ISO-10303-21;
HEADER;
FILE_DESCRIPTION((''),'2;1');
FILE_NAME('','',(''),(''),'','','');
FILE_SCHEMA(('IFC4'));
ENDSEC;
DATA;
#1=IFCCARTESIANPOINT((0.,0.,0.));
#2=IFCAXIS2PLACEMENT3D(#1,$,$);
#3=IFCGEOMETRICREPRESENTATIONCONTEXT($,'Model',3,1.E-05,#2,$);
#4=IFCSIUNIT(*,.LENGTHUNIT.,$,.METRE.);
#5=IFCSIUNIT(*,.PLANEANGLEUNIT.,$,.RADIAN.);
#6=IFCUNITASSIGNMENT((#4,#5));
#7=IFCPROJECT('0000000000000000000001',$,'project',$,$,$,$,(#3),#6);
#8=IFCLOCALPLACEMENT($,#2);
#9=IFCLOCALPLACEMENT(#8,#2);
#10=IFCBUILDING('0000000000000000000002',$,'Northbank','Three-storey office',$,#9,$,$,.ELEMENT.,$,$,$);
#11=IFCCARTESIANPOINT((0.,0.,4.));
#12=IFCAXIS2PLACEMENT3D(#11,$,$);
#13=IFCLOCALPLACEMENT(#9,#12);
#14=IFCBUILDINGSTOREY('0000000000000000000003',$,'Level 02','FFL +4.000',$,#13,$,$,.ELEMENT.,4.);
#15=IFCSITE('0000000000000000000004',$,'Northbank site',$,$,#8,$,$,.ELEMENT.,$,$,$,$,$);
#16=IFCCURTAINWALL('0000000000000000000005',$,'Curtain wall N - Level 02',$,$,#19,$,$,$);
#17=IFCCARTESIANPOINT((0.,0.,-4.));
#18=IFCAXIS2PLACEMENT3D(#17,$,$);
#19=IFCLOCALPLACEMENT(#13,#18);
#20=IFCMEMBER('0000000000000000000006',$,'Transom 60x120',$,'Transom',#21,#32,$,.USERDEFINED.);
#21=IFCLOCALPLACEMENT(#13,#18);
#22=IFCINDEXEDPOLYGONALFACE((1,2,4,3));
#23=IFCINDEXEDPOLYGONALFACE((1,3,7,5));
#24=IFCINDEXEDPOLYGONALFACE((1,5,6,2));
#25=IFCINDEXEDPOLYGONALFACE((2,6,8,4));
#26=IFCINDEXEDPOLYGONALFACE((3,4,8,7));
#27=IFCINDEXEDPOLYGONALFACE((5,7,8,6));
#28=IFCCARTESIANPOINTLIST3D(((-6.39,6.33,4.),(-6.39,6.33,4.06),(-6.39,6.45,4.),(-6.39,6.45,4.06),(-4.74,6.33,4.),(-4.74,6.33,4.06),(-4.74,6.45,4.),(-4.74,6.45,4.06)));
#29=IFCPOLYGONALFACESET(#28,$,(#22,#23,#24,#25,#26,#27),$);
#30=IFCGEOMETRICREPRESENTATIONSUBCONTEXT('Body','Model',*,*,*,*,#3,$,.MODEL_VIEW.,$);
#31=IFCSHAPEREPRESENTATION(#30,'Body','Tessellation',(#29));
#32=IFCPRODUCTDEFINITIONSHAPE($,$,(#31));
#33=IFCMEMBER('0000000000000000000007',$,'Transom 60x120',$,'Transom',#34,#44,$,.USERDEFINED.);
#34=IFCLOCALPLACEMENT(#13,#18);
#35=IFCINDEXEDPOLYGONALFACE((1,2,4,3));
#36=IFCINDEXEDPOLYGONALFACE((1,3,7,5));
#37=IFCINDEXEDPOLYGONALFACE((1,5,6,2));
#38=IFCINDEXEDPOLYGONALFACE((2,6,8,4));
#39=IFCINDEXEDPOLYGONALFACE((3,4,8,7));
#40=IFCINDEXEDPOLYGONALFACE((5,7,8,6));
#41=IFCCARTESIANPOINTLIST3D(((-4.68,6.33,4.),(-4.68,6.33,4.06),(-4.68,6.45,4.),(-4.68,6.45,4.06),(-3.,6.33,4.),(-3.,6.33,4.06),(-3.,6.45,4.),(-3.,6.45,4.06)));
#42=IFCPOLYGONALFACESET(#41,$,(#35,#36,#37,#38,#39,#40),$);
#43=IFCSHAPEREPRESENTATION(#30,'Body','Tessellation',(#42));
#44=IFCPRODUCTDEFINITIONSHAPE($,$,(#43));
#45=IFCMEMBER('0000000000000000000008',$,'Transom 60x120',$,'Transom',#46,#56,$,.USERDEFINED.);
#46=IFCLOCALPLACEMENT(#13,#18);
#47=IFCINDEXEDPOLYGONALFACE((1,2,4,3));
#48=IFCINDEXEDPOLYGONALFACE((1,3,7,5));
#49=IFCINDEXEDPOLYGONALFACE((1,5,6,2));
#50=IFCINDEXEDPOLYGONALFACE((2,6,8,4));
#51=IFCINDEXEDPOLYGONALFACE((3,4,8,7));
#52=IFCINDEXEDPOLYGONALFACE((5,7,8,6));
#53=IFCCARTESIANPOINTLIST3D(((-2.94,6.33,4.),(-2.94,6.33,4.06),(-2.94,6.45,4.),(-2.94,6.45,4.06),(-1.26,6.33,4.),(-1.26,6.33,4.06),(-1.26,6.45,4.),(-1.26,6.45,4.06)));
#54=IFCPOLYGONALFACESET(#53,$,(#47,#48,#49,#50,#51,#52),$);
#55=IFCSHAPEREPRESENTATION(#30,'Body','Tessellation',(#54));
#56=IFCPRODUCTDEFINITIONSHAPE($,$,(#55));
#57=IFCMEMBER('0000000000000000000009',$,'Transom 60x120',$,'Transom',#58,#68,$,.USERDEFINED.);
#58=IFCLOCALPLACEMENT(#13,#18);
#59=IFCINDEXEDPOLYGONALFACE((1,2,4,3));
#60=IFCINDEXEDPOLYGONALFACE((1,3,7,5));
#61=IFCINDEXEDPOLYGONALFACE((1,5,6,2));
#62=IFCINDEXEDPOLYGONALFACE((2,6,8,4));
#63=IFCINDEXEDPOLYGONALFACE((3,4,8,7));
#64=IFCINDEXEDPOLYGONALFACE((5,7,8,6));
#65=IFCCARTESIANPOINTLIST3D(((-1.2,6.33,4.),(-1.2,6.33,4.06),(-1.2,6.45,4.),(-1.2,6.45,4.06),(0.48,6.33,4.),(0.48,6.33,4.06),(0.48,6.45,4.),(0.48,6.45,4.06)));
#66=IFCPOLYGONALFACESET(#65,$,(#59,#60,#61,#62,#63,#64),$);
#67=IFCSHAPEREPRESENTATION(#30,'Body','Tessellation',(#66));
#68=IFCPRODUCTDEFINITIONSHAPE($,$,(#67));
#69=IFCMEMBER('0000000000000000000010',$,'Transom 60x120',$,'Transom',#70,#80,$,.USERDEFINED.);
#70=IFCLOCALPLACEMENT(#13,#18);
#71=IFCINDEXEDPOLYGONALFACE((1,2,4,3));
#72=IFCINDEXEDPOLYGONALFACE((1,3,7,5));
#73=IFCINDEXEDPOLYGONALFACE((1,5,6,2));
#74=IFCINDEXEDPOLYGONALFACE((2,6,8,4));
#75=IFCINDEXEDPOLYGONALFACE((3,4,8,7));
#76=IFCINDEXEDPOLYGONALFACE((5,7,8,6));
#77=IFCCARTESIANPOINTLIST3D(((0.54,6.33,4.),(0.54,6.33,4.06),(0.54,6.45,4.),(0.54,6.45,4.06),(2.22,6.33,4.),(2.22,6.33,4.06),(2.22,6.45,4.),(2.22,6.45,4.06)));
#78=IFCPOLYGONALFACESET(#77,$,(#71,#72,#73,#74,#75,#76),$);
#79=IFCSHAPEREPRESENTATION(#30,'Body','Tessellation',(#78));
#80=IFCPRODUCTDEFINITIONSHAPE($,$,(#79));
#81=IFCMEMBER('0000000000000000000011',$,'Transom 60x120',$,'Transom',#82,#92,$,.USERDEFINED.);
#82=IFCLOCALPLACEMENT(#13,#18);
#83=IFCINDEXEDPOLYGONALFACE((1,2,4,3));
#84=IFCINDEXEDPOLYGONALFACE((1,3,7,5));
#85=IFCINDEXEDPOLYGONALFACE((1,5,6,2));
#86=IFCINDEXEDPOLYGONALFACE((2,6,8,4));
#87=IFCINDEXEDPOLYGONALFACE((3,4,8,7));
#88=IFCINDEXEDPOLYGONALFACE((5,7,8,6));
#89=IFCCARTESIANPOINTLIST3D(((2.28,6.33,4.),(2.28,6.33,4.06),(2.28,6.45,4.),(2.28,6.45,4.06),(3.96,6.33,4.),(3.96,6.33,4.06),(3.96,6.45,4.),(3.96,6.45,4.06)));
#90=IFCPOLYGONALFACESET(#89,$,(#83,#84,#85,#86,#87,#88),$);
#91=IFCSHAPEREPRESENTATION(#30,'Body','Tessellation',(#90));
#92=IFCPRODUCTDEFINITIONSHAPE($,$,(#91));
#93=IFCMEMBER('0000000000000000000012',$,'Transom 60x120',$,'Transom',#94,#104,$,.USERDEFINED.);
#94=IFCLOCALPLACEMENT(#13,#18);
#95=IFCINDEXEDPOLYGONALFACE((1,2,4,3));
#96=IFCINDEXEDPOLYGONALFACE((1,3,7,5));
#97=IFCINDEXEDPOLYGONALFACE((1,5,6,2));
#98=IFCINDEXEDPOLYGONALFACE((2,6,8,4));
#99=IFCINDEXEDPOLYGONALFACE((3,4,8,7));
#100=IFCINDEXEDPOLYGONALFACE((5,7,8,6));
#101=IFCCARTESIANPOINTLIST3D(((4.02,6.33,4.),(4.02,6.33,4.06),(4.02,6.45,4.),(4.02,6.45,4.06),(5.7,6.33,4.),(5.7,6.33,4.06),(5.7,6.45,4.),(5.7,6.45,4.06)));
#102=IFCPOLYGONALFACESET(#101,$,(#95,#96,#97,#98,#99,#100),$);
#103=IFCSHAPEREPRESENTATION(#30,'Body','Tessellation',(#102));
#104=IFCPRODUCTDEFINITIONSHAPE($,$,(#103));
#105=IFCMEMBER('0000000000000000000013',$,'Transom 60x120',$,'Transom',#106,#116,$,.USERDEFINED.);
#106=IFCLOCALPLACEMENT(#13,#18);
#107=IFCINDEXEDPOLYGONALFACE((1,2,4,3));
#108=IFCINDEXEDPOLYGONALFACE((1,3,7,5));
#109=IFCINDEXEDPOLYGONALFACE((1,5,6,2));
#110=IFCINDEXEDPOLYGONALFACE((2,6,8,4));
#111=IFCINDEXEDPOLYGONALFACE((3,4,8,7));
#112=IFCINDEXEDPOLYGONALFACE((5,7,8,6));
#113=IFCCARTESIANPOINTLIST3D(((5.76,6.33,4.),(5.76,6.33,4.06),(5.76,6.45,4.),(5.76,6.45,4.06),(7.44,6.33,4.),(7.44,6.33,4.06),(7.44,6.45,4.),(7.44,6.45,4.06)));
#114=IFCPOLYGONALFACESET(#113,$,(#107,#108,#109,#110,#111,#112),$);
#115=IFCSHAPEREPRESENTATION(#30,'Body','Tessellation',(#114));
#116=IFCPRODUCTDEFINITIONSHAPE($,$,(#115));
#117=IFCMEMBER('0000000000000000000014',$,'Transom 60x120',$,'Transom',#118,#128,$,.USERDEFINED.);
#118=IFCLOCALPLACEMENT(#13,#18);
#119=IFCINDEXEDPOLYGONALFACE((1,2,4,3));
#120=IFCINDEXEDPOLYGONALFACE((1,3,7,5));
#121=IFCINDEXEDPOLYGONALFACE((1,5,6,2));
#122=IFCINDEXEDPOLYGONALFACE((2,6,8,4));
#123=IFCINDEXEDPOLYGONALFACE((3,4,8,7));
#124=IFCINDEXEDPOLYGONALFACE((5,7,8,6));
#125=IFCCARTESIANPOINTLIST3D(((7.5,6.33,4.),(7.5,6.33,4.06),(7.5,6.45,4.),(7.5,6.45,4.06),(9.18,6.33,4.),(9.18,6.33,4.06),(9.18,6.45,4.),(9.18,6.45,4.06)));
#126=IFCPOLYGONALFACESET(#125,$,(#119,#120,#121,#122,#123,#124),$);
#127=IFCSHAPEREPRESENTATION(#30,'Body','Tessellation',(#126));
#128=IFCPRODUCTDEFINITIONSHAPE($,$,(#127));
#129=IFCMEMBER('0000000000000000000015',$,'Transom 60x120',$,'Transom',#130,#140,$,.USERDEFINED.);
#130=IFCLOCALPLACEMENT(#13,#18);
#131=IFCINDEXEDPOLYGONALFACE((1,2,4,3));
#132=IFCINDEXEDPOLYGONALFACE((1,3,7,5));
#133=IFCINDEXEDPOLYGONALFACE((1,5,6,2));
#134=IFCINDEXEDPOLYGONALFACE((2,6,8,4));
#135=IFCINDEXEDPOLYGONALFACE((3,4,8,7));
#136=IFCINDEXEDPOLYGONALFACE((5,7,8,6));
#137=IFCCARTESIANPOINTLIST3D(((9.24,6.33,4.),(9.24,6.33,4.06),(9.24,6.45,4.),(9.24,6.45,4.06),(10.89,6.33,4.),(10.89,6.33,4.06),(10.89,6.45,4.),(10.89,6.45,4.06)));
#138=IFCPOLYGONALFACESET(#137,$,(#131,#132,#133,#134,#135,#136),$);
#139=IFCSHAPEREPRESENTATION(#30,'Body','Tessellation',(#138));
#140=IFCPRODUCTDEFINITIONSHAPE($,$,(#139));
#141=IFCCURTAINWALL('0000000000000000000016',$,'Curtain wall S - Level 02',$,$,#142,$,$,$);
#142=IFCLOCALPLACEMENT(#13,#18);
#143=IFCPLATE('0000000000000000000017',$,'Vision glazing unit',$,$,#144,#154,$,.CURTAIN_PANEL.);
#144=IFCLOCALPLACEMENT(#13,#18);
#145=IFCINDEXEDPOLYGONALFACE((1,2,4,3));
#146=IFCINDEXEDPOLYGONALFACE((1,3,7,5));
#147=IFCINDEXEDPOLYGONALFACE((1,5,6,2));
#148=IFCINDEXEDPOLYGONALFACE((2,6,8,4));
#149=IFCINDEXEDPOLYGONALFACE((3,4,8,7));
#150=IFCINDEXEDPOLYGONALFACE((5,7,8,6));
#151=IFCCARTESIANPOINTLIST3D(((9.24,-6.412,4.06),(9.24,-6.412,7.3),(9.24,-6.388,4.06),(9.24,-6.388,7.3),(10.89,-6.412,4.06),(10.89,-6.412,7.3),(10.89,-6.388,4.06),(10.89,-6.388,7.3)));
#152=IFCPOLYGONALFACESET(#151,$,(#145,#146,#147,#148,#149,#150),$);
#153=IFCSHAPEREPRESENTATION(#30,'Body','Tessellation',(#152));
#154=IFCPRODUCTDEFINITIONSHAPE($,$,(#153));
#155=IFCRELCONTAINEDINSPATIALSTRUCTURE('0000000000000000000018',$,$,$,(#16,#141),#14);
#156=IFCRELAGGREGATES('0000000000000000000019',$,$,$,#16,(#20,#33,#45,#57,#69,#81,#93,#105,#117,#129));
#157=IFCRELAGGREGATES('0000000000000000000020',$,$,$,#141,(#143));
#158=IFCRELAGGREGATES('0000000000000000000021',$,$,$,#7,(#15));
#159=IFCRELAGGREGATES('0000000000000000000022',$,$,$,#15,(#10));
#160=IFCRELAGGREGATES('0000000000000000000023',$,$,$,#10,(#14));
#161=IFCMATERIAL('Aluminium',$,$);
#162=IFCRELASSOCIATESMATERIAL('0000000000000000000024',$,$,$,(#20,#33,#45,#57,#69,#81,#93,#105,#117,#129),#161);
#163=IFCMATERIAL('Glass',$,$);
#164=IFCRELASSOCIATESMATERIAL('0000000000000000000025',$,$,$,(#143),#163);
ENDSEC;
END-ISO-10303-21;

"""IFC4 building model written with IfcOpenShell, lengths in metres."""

from ifc_helpers import new_model, si_unit, frame, origin, place, context, subcontext, project, spatial, rectangle, extrude, material, element, aggregate, save


model = new_model("IFC4")

# Units and contexts
model_context = context("Model", 3, precision=1e-05, world=origin())
body_context = subcontext(model_context, "Body", "Model", "MODEL_VIEW")
ifc_project = project(units=[si_unit("LENGTHUNIT", "METRE"), si_unit("PLANEANGLEUNIT", "RADIAN")], contexts=[model_context])

# Site, building, storey
site_placement = place(None, origin())
site = spatial("IfcSite", under=ifc_project, at=site_placement, Name="Northbank site", CompositionType="ELEMENT")
building_placement = place(site_placement, origin())
building = spatial("IfcBuilding", under=site, at=building_placement, Name="Northbank", Description="Three-storey office", CompositionType="ELEMENT")
storey_placement = place(building_placement, frame((0.0, 0.0, 4.0)))
storey = spatial("IfcBuildingStorey", under=building, at=storey_placement, Name="Level 02", Description="FFL +4.000", CompositionType="ELEMENT", Elevation=4.0)

# Curtain wall, members
curtain_wall_1_placement = place(storey_placement, frame((0.0, 0.0, -4.0)))
curtain_wall_1 = element("IfcCurtainWall", 1, at=curtain_wall_1_placement, inside=storey, Name="Curtain wall N - Level 02")
ifc_material_1 = material(Name="Aluminium")
member_1_placement = place(storey_placement, frame((0.0, 0.0, -4.0)))
member_1 = element("IfcMember", 2, at=member_1_placement, material=ifc_material_1, Name="Transom 60x120", ObjectType="Transom", PredefinedType="USERDEFINED", context=body_context, shape_type="SweptSolid", body=[
    extrude(rectangle(XDim=1.65, YDim=0.12), frame((-5.565, 6.39, 4.0)), (0.0, 0.0, 1.0), 0.06),
])
member_2_placement = place(storey_placement, frame((0.0, 0.0, -4.0)))
member_2 = element("IfcMember", 3, at=member_2_placement, material=ifc_material_1, Name="Transom 60x120", ObjectType="Transom", PredefinedType="USERDEFINED", context=body_context, shape_type="SweptSolid", body=[
    extrude(rectangle(XDim=1.68, YDim=0.12), frame((-3.84, 6.39, 4.0)), (0.0, 0.0, 1.0), 0.06),
])
member_3_placement = place(storey_placement, frame((0.0, 0.0, -4.0)))
member_3 = element("IfcMember", 4, at=member_3_placement, material=ifc_material_1, Name="Transom 60x120", ObjectType="Transom", PredefinedType="USERDEFINED", context=body_context, shape_type="SweptSolid", body=[
    extrude(rectangle(XDim=1.68, YDim=0.12), frame((-2.1, 6.39, 4.0)), (0.0, 0.0, 1.0), 0.06),
])
member_4_placement = place(storey_placement, frame((0.0, 0.0, -4.0)))
member_4 = element("IfcMember", 5, at=member_4_placement, material=ifc_material_1, Name="Transom 60x120", ObjectType="Transom", PredefinedType="USERDEFINED", context=body_context, shape_type="SweptSolid", body=[
    extrude(rectangle(XDim=1.68, YDim=0.12), frame((-0.36, 6.39, 4.0)), (0.0, 0.0, 1.0), 0.06),
])
member_5_placement = place(storey_placement, frame((0.0, 0.0, -4.0)))
member_5 = element("IfcMember", 6, at=member_5_placement, material=ifc_material_1, Name="Transom 60x120", ObjectType="Transom", PredefinedType="USERDEFINED", context=body_context, shape_type="SweptSolid", body=[
    extrude(rectangle(XDim=1.68, YDim=0.12), frame((1.38, 6.39, 4.0)), (0.0, 0.0, 1.0), 0.06),
])
member_6_placement = place(storey_placement, frame((0.0, 0.0, -4.0)))
member_6 = element("IfcMember", 7, at=member_6_placement, material=ifc_material_1, Name="Transom 60x120", ObjectType="Transom", PredefinedType="USERDEFINED", context=body_context, shape_type="SweptSolid", body=[
    extrude(rectangle(XDim=1.68, YDim=0.12), frame((3.12, 6.39, 4.0)), (0.0, 0.0, 1.0), 0.06),
])
member_7_placement = place(storey_placement, frame((0.0, 0.0, -4.0)))
member_7 = element("IfcMember", 8, at=member_7_placement, material=ifc_material_1, Name="Transom 60x120", ObjectType="Transom", PredefinedType="USERDEFINED", context=body_context, shape_type="SweptSolid", body=[
    extrude(rectangle(XDim=1.68, YDim=0.12), frame((4.86, 6.39, 4.0)), (0.0, 0.0, 1.0), 0.06),
])
member_8_placement = place(storey_placement, frame((0.0, 0.0, -4.0)))
member_8 = element("IfcMember", 9, at=member_8_placement, material=ifc_material_1, Name="Transom 60x120", ObjectType="Transom", PredefinedType="USERDEFINED", context=body_context, shape_type="SweptSolid", body=[
    extrude(rectangle(XDim=1.68, YDim=0.12), frame((6.6, 6.39, 4.0)), (0.0, 0.0, 1.0), 0.06),
])
member_9_placement = place(storey_placement, frame((0.0, 0.0, -4.0)))
member_9 = element("IfcMember", 10, at=member_9_placement, material=ifc_material_1, Name="Transom 60x120", ObjectType="Transom", PredefinedType="USERDEFINED", context=body_context, shape_type="SweptSolid", body=[
    extrude(rectangle(XDim=1.68, YDim=0.12), frame((8.34, 6.39, 4.0)), (0.0, 0.0, 1.0), 0.06),
])
member_10_placement = place(storey_placement, frame((0.0, 0.0, -4.0)))
member_10 = element("IfcMember", 11, at=member_10_placement, material=ifc_material_1, Name="Transom 60x120", ObjectType="Transom", PredefinedType="USERDEFINED", context=body_context, shape_type="SweptSolid", body=[
    extrude(rectangle(XDim=1.65, YDim=0.12), frame((10.065, 6.39, 4.0)), (0.0, 0.0, 1.0), 0.06),
])
aggregate(curtain_wall_1, [member_1, member_2, member_3, member_4, member_5, member_6, member_7, member_8, member_9, member_10])

# Curtain wall, plate
curtain_wall_2_placement = place(storey_placement, frame((0.0, 0.0, -4.0)))
curtain_wall_2 = element("IfcCurtainWall", 12, at=curtain_wall_2_placement, inside=storey, Name="Curtain wall S - Level 02")
ifc_material_2 = material(Name="Glass")
plate_1_placement = place(storey_placement, frame((0.0, 0.0, -4.0)))
plate_1 = element("IfcPlate", 13, at=plate_1_placement, material=ifc_material_2, Name="Vision glazing unit", PredefinedType="CURTAIN_PANEL", context=body_context, shape_type="SweptSolid", body=[
    extrude(rectangle(XDim=1.65, YDim=0.024), frame((10.065, -6.4, 4.06)), (0.0, 0.0, 1.0), 3.24),
])
aggregate(curtain_wall_2, [plate_1])

save(model, "model.ifc")
